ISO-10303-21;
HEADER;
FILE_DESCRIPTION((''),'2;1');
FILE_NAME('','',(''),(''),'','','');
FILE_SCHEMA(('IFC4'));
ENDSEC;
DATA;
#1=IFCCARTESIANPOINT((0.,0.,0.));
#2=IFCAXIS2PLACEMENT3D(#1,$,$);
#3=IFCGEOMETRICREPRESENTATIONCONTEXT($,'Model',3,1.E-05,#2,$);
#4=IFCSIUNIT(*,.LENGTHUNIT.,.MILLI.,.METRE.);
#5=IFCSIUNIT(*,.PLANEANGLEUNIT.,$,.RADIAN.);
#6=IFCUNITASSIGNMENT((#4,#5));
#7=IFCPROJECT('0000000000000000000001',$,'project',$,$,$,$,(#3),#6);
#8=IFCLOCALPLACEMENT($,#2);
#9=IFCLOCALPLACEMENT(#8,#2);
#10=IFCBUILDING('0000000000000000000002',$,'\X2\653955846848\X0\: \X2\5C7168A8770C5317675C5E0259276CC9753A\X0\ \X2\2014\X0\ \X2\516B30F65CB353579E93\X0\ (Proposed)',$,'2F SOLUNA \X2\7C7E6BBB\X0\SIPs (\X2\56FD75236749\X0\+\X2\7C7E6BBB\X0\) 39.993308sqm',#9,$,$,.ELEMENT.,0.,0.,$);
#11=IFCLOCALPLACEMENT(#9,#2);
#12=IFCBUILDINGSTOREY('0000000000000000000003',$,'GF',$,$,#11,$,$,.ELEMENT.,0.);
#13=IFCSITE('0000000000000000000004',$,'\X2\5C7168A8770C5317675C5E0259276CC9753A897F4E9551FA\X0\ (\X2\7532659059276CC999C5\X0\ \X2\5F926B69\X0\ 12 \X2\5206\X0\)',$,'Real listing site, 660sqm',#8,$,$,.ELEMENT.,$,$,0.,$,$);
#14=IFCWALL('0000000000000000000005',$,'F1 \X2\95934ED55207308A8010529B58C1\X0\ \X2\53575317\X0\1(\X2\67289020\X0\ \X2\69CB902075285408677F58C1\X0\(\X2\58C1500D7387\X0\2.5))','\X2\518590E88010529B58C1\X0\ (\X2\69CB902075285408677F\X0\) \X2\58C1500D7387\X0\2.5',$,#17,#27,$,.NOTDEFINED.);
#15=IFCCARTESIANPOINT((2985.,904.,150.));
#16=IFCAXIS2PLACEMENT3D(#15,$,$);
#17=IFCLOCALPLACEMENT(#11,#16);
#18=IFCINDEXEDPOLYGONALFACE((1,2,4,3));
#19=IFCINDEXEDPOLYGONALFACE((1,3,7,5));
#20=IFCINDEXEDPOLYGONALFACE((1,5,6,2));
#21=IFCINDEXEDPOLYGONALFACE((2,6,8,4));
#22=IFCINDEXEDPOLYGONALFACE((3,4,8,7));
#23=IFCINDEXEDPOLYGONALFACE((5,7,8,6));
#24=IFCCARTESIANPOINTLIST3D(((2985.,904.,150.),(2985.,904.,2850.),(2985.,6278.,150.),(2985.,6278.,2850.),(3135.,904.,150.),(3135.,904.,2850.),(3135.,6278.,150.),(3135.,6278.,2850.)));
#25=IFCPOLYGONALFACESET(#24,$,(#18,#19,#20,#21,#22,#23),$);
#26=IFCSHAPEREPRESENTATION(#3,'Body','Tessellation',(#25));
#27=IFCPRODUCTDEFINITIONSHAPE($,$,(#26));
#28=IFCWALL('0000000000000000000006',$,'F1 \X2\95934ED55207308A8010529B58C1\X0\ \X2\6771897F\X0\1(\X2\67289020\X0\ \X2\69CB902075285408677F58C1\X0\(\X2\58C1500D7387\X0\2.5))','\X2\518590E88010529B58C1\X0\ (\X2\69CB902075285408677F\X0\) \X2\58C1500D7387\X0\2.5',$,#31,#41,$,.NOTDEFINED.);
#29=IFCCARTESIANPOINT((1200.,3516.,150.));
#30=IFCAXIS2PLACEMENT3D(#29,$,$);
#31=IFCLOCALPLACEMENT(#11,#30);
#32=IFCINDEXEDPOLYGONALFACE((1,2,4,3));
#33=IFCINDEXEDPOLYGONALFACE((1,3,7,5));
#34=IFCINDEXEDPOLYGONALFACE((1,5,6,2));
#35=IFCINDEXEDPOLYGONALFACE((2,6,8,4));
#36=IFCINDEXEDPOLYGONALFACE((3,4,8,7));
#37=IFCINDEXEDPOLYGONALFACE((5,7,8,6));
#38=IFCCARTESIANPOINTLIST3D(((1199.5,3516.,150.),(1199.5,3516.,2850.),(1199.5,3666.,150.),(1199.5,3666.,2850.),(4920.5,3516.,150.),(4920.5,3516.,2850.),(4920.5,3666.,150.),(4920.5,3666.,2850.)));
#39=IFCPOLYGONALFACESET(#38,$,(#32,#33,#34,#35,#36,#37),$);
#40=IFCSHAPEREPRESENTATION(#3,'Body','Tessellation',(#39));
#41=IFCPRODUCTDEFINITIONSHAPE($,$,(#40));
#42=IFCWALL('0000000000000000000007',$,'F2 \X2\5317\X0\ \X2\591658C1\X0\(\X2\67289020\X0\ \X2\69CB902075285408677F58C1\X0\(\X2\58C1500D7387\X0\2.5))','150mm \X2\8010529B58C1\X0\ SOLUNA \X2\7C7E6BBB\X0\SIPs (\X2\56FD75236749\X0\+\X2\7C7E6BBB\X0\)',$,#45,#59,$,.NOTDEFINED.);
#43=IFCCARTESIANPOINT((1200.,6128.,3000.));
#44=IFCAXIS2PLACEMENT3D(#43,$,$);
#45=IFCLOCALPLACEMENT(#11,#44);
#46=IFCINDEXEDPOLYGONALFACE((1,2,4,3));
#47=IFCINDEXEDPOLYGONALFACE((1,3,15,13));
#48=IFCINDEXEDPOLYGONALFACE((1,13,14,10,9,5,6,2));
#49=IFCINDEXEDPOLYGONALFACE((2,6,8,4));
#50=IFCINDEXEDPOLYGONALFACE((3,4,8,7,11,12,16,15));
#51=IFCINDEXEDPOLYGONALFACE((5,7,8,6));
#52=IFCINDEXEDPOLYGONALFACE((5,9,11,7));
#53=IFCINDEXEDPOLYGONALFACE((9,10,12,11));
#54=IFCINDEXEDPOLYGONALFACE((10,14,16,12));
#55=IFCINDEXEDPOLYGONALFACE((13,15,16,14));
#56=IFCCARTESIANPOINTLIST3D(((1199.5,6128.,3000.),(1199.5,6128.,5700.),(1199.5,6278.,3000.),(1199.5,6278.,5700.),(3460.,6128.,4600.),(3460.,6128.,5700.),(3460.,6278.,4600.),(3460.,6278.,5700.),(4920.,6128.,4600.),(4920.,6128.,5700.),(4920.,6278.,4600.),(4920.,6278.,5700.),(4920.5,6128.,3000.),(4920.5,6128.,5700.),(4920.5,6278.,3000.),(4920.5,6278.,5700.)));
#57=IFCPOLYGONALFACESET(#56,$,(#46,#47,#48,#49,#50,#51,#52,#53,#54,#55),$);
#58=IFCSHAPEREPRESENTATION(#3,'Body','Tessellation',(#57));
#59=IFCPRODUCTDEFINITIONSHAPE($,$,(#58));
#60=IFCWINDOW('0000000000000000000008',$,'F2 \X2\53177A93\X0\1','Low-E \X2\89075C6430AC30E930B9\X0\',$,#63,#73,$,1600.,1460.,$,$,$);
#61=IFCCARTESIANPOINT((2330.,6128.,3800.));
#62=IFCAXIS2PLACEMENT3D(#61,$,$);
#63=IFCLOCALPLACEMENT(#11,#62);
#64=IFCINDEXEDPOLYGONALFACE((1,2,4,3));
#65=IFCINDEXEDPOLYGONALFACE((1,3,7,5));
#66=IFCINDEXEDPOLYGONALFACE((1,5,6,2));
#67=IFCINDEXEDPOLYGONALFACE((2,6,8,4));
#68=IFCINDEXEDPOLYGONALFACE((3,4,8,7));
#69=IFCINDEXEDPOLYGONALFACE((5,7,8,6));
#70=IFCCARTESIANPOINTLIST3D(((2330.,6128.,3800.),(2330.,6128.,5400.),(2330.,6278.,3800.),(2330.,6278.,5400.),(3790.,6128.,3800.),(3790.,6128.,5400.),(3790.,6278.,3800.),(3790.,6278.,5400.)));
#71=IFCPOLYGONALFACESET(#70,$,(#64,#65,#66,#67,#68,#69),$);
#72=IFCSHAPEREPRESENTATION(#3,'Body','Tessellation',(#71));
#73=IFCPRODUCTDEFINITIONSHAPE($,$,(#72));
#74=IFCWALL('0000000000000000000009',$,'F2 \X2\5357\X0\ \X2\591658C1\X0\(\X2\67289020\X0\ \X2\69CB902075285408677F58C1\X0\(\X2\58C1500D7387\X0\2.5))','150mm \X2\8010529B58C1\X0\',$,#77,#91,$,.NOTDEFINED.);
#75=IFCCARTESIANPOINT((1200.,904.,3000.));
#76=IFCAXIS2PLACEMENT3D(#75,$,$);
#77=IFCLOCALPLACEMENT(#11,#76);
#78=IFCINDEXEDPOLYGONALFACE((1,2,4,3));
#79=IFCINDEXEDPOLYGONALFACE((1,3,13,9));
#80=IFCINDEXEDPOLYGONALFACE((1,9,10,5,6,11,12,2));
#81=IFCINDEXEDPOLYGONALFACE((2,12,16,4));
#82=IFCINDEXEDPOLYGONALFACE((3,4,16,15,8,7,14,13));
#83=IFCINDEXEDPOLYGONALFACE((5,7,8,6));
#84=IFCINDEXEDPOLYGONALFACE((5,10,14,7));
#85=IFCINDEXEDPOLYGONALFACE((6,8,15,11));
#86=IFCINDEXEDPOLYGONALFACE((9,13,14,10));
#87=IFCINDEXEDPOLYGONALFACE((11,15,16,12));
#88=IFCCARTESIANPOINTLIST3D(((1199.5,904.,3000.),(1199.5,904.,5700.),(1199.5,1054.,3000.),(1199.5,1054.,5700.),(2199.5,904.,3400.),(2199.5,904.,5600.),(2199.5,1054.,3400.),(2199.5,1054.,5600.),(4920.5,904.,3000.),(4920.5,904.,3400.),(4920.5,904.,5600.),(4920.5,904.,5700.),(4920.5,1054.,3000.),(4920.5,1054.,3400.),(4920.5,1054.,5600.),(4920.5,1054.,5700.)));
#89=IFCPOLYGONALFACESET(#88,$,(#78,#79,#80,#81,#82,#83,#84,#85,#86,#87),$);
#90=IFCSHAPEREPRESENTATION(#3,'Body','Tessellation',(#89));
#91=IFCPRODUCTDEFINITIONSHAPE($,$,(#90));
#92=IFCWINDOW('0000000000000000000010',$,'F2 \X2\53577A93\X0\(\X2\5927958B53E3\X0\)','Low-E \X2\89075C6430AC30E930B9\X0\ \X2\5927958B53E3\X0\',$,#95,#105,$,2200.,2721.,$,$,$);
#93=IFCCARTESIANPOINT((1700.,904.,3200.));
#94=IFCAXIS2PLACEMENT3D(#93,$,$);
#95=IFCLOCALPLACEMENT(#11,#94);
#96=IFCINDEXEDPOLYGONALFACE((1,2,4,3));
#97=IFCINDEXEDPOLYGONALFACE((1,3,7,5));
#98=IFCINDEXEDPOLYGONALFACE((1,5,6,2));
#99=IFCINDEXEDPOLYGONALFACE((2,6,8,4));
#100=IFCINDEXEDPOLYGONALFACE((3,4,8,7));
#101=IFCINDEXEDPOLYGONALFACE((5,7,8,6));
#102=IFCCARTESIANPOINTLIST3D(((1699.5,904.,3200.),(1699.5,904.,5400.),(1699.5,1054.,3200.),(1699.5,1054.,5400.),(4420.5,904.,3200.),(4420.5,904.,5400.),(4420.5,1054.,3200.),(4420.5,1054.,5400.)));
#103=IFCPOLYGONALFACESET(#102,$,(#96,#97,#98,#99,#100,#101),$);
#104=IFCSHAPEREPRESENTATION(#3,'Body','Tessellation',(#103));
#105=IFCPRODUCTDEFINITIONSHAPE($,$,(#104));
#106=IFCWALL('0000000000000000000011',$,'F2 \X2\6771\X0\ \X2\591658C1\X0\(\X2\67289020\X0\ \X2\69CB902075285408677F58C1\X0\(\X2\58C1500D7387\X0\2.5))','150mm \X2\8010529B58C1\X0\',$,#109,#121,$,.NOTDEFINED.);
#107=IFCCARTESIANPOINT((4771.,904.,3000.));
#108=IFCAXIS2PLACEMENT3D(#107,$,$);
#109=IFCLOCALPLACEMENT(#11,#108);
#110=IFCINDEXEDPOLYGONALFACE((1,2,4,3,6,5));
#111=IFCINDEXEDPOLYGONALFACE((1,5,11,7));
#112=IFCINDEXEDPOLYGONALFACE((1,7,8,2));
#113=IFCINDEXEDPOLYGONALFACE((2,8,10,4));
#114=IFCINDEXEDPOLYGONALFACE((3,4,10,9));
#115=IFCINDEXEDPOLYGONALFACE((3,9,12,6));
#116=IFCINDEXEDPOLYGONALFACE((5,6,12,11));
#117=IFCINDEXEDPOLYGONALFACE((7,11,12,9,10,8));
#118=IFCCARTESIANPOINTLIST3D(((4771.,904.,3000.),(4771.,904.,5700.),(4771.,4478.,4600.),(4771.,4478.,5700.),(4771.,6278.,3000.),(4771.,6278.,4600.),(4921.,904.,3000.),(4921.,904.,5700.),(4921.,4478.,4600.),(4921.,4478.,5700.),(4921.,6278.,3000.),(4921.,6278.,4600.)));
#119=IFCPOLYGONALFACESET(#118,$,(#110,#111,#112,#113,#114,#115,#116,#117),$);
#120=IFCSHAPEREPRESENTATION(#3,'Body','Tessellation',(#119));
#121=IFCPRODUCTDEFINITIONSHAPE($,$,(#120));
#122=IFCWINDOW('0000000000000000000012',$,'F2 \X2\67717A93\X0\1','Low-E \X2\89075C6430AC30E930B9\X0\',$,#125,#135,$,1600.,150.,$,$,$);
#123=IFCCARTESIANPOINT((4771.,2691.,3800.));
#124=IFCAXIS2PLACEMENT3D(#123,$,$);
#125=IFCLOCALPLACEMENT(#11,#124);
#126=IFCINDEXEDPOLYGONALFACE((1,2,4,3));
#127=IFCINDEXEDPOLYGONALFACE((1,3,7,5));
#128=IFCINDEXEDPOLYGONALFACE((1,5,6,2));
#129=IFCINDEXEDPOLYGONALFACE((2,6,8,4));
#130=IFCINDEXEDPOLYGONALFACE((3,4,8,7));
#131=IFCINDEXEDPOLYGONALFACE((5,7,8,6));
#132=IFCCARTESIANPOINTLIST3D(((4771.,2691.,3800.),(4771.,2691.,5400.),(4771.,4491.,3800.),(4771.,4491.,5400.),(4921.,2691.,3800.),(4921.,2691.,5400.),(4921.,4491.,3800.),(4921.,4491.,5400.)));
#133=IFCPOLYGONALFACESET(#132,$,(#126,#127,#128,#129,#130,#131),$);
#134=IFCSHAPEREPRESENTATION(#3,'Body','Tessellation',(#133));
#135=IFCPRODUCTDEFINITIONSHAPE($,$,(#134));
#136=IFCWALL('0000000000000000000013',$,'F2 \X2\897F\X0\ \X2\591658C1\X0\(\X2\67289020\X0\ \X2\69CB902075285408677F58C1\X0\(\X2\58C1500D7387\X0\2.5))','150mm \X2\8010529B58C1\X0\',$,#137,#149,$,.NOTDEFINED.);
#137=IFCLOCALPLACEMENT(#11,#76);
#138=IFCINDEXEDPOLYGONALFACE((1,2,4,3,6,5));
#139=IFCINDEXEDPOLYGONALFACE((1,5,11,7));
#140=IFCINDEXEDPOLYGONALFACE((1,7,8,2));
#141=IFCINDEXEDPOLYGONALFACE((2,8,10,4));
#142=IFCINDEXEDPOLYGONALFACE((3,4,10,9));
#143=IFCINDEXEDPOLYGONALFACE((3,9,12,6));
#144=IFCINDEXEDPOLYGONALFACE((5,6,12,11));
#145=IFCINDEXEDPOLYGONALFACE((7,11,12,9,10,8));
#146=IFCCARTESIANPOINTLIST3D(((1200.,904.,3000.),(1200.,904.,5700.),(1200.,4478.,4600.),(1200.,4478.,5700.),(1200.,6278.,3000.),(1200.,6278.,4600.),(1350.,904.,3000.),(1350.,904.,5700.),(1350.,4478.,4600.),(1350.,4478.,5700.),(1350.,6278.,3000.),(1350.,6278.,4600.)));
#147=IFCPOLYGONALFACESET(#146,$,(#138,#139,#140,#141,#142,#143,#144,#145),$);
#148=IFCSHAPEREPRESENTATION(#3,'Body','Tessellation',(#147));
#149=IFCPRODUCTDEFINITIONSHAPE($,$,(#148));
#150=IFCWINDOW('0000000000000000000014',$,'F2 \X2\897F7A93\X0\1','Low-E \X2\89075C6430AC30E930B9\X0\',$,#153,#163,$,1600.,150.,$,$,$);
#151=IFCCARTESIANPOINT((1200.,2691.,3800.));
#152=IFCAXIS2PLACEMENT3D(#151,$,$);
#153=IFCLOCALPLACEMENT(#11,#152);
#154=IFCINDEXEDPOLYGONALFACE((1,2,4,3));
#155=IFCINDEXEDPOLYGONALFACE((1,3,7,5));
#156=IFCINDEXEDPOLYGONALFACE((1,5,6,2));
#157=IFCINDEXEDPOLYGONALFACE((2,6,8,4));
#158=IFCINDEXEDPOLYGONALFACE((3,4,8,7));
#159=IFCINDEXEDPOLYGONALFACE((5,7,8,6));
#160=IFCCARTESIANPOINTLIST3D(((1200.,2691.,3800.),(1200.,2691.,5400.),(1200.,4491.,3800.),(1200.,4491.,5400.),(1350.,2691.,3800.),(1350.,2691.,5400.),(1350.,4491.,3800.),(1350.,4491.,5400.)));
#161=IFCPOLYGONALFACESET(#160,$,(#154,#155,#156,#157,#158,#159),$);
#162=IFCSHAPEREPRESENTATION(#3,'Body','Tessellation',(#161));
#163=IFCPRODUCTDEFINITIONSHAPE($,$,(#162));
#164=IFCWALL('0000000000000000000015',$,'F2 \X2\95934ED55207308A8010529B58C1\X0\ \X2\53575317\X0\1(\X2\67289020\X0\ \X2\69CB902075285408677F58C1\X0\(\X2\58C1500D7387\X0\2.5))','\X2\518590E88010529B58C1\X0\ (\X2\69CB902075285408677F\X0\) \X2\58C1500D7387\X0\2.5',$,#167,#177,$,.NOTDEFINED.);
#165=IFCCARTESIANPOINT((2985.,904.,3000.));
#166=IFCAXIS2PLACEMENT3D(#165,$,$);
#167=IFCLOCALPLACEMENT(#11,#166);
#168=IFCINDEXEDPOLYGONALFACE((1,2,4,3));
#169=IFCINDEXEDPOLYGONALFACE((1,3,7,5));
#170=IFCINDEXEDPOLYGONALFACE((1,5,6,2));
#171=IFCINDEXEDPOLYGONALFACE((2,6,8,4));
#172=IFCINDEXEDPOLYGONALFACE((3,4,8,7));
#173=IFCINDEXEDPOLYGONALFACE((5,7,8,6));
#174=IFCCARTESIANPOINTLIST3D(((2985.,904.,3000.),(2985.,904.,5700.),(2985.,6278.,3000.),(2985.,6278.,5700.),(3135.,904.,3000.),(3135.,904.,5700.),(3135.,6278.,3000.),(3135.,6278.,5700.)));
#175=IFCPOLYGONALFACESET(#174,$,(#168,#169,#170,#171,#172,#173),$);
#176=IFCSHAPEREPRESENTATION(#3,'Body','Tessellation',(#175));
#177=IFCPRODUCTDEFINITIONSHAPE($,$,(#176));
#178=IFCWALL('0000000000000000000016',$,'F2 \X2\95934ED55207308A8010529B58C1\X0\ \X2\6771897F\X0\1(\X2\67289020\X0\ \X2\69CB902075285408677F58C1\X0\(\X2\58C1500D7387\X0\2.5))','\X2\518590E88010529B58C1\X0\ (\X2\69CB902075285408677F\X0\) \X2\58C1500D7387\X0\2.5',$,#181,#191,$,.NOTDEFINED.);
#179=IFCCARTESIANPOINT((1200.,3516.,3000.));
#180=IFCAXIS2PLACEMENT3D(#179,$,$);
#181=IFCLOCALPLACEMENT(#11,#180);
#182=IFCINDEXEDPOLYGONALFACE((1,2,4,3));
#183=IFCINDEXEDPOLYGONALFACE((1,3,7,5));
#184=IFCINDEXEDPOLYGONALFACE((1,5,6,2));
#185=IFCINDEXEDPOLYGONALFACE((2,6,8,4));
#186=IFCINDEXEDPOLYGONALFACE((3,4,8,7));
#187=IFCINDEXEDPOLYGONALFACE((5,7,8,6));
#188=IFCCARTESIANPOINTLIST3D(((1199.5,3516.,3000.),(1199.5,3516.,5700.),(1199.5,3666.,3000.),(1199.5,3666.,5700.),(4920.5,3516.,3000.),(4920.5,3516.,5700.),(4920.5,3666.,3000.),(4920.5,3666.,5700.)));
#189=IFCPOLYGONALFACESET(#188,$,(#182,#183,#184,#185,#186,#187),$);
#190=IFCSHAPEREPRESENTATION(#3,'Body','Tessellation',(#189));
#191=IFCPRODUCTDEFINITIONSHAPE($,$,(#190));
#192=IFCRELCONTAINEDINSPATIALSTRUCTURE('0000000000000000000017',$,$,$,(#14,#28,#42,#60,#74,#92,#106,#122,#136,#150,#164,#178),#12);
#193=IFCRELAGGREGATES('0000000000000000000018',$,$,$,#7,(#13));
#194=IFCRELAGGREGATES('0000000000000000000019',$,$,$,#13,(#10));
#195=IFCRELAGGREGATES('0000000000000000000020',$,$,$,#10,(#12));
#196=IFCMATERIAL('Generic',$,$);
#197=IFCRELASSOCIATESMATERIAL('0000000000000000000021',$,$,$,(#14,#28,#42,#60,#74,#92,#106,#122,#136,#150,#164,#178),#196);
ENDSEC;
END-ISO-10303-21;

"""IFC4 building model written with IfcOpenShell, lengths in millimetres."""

from ifc_helpers import new_model, si_unit, frame, frame_2d, origin, place, context, project, spatial, rectangle, extrude, material, element, fill, save


model = new_model("IFC4")

# Units and contexts
model_context = context("Model", 3, precision=1e-05, world=origin())
ifc_project = project(units=[si_unit("LENGTHUNIT", "METRE", prefix="MILLI"), si_unit("PLANEANGLEUNIT", "RADIAN")], contexts=[model_context])

# Site, building, storey
site_placement = place(None, origin())
site = spatial("IfcSite", under=ifc_project, at=site_placement, Name="山梨県北杜市大泉町西井出 (甲斐大泉駅 徒歩 12 分)", ObjectType="Real listing site, 660sqm", CompositionType="ELEMENT", RefElevation=0.0)
building_placement = place(site_placement, origin())
building = spatial("IfcBuilding", under=site, at=building_placement, Name="改善案: 山梨県北杜市大泉町 — 八ヶ岳南麓 (Proposed)", ObjectType="2F SOLUNA 籾殻SIPs (国産杉+籾殻) 39.993308sqm", CompositionType="ELEMENT", ElevationOfRefHeight=0.0, ElevationOfTerrain=0.0)
storey_placement = place(building_placement, origin())
storey = spatial("IfcBuildingStorey", under=building, at=storey_placement, Name="GF", CompositionType="ELEMENT", Elevation=0.0)

# Shared definitions
ifc_material_1 = material(Name="Generic")

# Walls
wall_1_placement = place(storey_placement, frame((2985.0, 904.0, 150.0)))
element("IfcWall", 1, at=wall_1_placement, inside=storey, material=ifc_material_1, Name="F1 間仕切り耐力壁 南北1(木造 構造用合板壁(壁倍率2.5))", Description="内部耐力壁 (構造用合板) 壁倍率2.5", PredefinedType="NOTDEFINED", context=model_context, shape_type="SweptSolid", body=[
    extrude(rectangle(XDim=150.0, YDim=5374.0, at=frame_2d((75.0, 2687.0))), frame((2985.0, 904.0, 150.0)), (0.0, 0.0, 1.0), 2700.0),
])
wall_2_placement = place(storey_placement, frame((1200.0, 3516.0, 150.0)))
element("IfcWall", 2, at=wall_2_placement, inside=storey, material=ifc_material_1, Name="F1 間仕切り耐力壁 東西1(木造 構造用合板壁(壁倍率2.5))", Description="内部耐力壁 (構造用合板) 壁倍率2.5", PredefinedType="NOTDEFINED", context=model_context, shape_type="SweptSolid", body=[
    extrude(rectangle(XDim=3721.0, YDim=150.0, at=frame_2d((1860.0, 75.0))), frame((1200.0, 3516.0, 150.0)), (0.0, 0.0, 1.0), 2700.0),
])

# Walls, openings, windows
wall_3_placement = place(storey_placement, frame((1200.0, 6128.0, 3000.0)))
wall_3 = element("IfcWall", 3, at=wall_3_placement, inside=storey, material=ifc_material_1, Name="F2 北 外壁(木造 構造用合板壁(壁倍率2.5))", Description="150mm 耐力壁 SOLUNA 籾殻SIPs (国産杉+籾殻)", PredefinedType="NOTDEFINED", context=model_context, shape_type="SweptSolid", body=[
    extrude(rectangle(XDim=3721.0, YDim=150.0, at=frame_2d((1860.0, 75.0))), frame((1200.0, 6128.0, 3000.0)), (0.0, 0.0, 1.0), 2700.0),
])
opening_1_placement = place(storey_placement, frame((2330.0, 6128.0, 3800.0)))
opening_1 = element("IfcOpeningElement", 4, at=opening_1_placement, cuts=wall_3, PredefinedType="NOTDEFINED", context=model_context, shape_type="SweptSolid", body=[
    extrude(rectangle(XDim=1460.0, YDim=150.0, at=frame_2d((730.0, 75.0))), frame((2330.0, 6128.0, 3800.0)), (0.0, 0.0, 1.0), 1600.0),
])
window_1_placement = place(storey_placement, frame((2330.0, 6128.0, 3800.0)))
window_1 = element("IfcWindow", 5, at=window_1_placement, inside=storey, material=ifc_material_1, Name="F2 北窓1", Description="Low-E 複層ガラス", OverallHeight=1600.0, OverallWidth=1460.0, context=model_context, shape_type="SweptSolid", body=[
    extrude(rectangle(XDim=1460.0, YDim=150.0, at=frame_2d((730.0, 75.0))), frame((2330.0, 6128.0, 3800.0)), (0.0, 0.0, 1.0), 1600.0),
])
fill(opening_1, window_1)
wall_4_placement = place(storey_placement, frame((1200.0, 904.0, 3000.0)))
wall_4 = element("IfcWall", 6, at=wall_4_placement, inside=storey, material=ifc_material_1, Name="F2 南 外壁(木造 構造用合板壁(壁倍率2.5))", Description="150mm 耐力壁", PredefinedType="NOTDEFINED", context=model_context, shape_type="SweptSolid", body=[
    extrude(rectangle(XDim=3721.0, YDim=150.0, at=frame_2d((1860.0, 75.0))), frame((1200.0, 904.0, 3000.0)), (0.0, 0.0, 1.0), 2700.0),
])
opening_2_placement = place(storey_placement, frame((1700.0, 904.0, 3200.0)))
opening_2 = element("IfcOpeningElement", 7, at=opening_2_placement, cuts=wall_4, PredefinedType="NOTDEFINED", context=model_context, shape_type="SweptSolid", body=[
    extrude(rectangle(XDim=2721.0, YDim=150.0, at=frame_2d((1360.0, 75.0))), frame((1700.0, 904.0, 3200.0)), (0.0, 0.0, 1.0), 2200.0),
])
window_2_placement = place(storey_placement, frame((1700.0, 904.0, 3200.0)))
window_2 = element("IfcWindow", 8, at=window_2_placement, inside=storey, material=ifc_material_1, Name="F2 南窓(大開口)", Description="Low-E 複層ガラス 大開口", OverallHeight=2200.0, OverallWidth=2721.0, context=model_context, shape_type="SweptSolid", body=[
    extrude(rectangle(XDim=2721.0, YDim=150.0, at=frame_2d((1360.0, 75.0))), frame((1700.0, 904.0, 3200.0)), (0.0, 0.0, 1.0), 2200.0),
])
fill(opening_2, window_2)
wall_5_placement = place(storey_placement, frame((4771.0, 904.0, 3000.0)))
wall_5 = element("IfcWall", 9, at=wall_5_placement, inside=storey, material=ifc_material_1, Name="F2 東 外壁(木造 構造用合板壁(壁倍率2.5))", Description="150mm 耐力壁", PredefinedType="NOTDEFINED", context=model_context, shape_type="SweptSolid", body=[
    extrude(rectangle(XDim=150.0, YDim=5374.0, at=frame_2d((75.0, 2687.0))), frame((4771.0, 904.0, 3000.0)), (0.0, 0.0, 1.0), 2700.0),
])
opening_3_placement = place(storey_placement, frame((4771.0, 2691.0, 3800.0)))
opening_3 = element("IfcOpeningElement", 10, at=opening_3_placement, cuts=wall_5, PredefinedType="NOTDEFINED", context=model_context, shape_type="SweptSolid", body=[
    extrude(rectangle(XDim=150.0, YDim=1800.0, at=frame_2d((75.0, 900.0))), frame((4771.0, 2691.0, 3800.0)), (0.0, 0.0, 1.0), 1600.0),
])
window_3_placement = place(storey_placement, frame((4771.0, 2691.0, 3800.0)))
window_3 = element("IfcWindow", 11, at=window_3_placement, inside=storey, material=ifc_material_1, Name="F2 東窓1", Description="Low-E 複層ガラス", OverallHeight=1600.0, OverallWidth=150.0, context=model_context, shape_type="SweptSolid", body=[
    extrude(rectangle(XDim=150.0, YDim=1800.0, at=frame_2d((75.0, 900.0))), frame((4771.0, 2691.0, 3800.0)), (0.0, 0.0, 1.0), 1600.0),
])
fill(opening_3, window_3)
wall_6_placement = place(storey_placement, frame((1200.0, 904.0, 3000.0)))
wall_6 = element("IfcWall", 12, at=wall_6_placement, inside=storey, material=ifc_material_1, Name="F2 西 外壁(木造 構造用合板壁(壁倍率2.5))", Description="150mm 耐力壁", PredefinedType="NOTDEFINED", context=model_context, shape_type="SweptSolid", body=[
    extrude(rectangle(XDim=150.0, YDim=5374.0, at=frame_2d((75.0, 2687.0))), frame((1200.0, 904.0, 3000.0)), (0.0, 0.0, 1.0), 2700.0),
])
opening_4_placement = place(storey_placement, frame((1200.0, 2691.0, 3800.0)))
opening_4 = element("IfcOpeningElement", 13, at=opening_4_placement, cuts=wall_6, PredefinedType="NOTDEFINED", context=model_context, shape_type="SweptSolid", body=[
    extrude(rectangle(XDim=150.0, YDim=1800.0, at=frame_2d((75.0, 900.0))), frame((1200.0, 2691.0, 3800.0)), (0.0, 0.0, 1.0), 1600.0),
])
window_4_placement = place(storey_placement, frame((1200.0, 2691.0, 3800.0)))
window_4 = element("IfcWindow", 14, at=window_4_placement, inside=storey, material=ifc_material_1, Name="F2 西窓1", Description="Low-E 複層ガラス", OverallHeight=1600.0, OverallWidth=150.0, context=model_context, shape_type="SweptSolid", body=[
    extrude(rectangle(XDim=150.0, YDim=1800.0, at=frame_2d((75.0, 900.0))), frame((1200.0, 2691.0, 3800.0)), (0.0, 0.0, 1.0), 1600.0),
])
fill(opening_4, window_4)

# Walls
wall_7_placement = place(storey_placement, frame((2985.0, 904.0, 3000.0)))
element("IfcWall", 15, at=wall_7_placement, inside=storey, material=ifc_material_1, Name="F2 間仕切り耐力壁 南北1(木造 構造用合板壁(壁倍率2.5))", Description="内部耐力壁 (構造用合板) 壁倍率2.5", PredefinedType="NOTDEFINED", context=model_context, shape_type="SweptSolid", body=[
    extrude(rectangle(XDim=150.0, YDim=5374.0, at=frame_2d((75.0, 2687.0))), frame((2985.0, 904.0, 3000.0)), (0.0, 0.0, 1.0), 2700.0),
])
wall_8_placement = place(storey_placement, frame((1200.0, 3516.0, 3000.0)))
element("IfcWall", 16, at=wall_8_placement, inside=storey, material=ifc_material_1, Name="F2 間仕切り耐力壁 東西1(木造 構造用合板壁(壁倍率2.5))", Description="内部耐力壁 (構造用合板) 壁倍率2.5", PredefinedType="NOTDEFINED", context=model_context, shape_type="SweptSolid", body=[
    extrude(rectangle(XDim=3721.0, YDim=150.0, at=frame_2d((1860.0, 75.0))), frame((1200.0, 3516.0, 3000.0)), (0.0, 0.0, 1.0), 2700.0),
])

save(model, "model.ifc")
